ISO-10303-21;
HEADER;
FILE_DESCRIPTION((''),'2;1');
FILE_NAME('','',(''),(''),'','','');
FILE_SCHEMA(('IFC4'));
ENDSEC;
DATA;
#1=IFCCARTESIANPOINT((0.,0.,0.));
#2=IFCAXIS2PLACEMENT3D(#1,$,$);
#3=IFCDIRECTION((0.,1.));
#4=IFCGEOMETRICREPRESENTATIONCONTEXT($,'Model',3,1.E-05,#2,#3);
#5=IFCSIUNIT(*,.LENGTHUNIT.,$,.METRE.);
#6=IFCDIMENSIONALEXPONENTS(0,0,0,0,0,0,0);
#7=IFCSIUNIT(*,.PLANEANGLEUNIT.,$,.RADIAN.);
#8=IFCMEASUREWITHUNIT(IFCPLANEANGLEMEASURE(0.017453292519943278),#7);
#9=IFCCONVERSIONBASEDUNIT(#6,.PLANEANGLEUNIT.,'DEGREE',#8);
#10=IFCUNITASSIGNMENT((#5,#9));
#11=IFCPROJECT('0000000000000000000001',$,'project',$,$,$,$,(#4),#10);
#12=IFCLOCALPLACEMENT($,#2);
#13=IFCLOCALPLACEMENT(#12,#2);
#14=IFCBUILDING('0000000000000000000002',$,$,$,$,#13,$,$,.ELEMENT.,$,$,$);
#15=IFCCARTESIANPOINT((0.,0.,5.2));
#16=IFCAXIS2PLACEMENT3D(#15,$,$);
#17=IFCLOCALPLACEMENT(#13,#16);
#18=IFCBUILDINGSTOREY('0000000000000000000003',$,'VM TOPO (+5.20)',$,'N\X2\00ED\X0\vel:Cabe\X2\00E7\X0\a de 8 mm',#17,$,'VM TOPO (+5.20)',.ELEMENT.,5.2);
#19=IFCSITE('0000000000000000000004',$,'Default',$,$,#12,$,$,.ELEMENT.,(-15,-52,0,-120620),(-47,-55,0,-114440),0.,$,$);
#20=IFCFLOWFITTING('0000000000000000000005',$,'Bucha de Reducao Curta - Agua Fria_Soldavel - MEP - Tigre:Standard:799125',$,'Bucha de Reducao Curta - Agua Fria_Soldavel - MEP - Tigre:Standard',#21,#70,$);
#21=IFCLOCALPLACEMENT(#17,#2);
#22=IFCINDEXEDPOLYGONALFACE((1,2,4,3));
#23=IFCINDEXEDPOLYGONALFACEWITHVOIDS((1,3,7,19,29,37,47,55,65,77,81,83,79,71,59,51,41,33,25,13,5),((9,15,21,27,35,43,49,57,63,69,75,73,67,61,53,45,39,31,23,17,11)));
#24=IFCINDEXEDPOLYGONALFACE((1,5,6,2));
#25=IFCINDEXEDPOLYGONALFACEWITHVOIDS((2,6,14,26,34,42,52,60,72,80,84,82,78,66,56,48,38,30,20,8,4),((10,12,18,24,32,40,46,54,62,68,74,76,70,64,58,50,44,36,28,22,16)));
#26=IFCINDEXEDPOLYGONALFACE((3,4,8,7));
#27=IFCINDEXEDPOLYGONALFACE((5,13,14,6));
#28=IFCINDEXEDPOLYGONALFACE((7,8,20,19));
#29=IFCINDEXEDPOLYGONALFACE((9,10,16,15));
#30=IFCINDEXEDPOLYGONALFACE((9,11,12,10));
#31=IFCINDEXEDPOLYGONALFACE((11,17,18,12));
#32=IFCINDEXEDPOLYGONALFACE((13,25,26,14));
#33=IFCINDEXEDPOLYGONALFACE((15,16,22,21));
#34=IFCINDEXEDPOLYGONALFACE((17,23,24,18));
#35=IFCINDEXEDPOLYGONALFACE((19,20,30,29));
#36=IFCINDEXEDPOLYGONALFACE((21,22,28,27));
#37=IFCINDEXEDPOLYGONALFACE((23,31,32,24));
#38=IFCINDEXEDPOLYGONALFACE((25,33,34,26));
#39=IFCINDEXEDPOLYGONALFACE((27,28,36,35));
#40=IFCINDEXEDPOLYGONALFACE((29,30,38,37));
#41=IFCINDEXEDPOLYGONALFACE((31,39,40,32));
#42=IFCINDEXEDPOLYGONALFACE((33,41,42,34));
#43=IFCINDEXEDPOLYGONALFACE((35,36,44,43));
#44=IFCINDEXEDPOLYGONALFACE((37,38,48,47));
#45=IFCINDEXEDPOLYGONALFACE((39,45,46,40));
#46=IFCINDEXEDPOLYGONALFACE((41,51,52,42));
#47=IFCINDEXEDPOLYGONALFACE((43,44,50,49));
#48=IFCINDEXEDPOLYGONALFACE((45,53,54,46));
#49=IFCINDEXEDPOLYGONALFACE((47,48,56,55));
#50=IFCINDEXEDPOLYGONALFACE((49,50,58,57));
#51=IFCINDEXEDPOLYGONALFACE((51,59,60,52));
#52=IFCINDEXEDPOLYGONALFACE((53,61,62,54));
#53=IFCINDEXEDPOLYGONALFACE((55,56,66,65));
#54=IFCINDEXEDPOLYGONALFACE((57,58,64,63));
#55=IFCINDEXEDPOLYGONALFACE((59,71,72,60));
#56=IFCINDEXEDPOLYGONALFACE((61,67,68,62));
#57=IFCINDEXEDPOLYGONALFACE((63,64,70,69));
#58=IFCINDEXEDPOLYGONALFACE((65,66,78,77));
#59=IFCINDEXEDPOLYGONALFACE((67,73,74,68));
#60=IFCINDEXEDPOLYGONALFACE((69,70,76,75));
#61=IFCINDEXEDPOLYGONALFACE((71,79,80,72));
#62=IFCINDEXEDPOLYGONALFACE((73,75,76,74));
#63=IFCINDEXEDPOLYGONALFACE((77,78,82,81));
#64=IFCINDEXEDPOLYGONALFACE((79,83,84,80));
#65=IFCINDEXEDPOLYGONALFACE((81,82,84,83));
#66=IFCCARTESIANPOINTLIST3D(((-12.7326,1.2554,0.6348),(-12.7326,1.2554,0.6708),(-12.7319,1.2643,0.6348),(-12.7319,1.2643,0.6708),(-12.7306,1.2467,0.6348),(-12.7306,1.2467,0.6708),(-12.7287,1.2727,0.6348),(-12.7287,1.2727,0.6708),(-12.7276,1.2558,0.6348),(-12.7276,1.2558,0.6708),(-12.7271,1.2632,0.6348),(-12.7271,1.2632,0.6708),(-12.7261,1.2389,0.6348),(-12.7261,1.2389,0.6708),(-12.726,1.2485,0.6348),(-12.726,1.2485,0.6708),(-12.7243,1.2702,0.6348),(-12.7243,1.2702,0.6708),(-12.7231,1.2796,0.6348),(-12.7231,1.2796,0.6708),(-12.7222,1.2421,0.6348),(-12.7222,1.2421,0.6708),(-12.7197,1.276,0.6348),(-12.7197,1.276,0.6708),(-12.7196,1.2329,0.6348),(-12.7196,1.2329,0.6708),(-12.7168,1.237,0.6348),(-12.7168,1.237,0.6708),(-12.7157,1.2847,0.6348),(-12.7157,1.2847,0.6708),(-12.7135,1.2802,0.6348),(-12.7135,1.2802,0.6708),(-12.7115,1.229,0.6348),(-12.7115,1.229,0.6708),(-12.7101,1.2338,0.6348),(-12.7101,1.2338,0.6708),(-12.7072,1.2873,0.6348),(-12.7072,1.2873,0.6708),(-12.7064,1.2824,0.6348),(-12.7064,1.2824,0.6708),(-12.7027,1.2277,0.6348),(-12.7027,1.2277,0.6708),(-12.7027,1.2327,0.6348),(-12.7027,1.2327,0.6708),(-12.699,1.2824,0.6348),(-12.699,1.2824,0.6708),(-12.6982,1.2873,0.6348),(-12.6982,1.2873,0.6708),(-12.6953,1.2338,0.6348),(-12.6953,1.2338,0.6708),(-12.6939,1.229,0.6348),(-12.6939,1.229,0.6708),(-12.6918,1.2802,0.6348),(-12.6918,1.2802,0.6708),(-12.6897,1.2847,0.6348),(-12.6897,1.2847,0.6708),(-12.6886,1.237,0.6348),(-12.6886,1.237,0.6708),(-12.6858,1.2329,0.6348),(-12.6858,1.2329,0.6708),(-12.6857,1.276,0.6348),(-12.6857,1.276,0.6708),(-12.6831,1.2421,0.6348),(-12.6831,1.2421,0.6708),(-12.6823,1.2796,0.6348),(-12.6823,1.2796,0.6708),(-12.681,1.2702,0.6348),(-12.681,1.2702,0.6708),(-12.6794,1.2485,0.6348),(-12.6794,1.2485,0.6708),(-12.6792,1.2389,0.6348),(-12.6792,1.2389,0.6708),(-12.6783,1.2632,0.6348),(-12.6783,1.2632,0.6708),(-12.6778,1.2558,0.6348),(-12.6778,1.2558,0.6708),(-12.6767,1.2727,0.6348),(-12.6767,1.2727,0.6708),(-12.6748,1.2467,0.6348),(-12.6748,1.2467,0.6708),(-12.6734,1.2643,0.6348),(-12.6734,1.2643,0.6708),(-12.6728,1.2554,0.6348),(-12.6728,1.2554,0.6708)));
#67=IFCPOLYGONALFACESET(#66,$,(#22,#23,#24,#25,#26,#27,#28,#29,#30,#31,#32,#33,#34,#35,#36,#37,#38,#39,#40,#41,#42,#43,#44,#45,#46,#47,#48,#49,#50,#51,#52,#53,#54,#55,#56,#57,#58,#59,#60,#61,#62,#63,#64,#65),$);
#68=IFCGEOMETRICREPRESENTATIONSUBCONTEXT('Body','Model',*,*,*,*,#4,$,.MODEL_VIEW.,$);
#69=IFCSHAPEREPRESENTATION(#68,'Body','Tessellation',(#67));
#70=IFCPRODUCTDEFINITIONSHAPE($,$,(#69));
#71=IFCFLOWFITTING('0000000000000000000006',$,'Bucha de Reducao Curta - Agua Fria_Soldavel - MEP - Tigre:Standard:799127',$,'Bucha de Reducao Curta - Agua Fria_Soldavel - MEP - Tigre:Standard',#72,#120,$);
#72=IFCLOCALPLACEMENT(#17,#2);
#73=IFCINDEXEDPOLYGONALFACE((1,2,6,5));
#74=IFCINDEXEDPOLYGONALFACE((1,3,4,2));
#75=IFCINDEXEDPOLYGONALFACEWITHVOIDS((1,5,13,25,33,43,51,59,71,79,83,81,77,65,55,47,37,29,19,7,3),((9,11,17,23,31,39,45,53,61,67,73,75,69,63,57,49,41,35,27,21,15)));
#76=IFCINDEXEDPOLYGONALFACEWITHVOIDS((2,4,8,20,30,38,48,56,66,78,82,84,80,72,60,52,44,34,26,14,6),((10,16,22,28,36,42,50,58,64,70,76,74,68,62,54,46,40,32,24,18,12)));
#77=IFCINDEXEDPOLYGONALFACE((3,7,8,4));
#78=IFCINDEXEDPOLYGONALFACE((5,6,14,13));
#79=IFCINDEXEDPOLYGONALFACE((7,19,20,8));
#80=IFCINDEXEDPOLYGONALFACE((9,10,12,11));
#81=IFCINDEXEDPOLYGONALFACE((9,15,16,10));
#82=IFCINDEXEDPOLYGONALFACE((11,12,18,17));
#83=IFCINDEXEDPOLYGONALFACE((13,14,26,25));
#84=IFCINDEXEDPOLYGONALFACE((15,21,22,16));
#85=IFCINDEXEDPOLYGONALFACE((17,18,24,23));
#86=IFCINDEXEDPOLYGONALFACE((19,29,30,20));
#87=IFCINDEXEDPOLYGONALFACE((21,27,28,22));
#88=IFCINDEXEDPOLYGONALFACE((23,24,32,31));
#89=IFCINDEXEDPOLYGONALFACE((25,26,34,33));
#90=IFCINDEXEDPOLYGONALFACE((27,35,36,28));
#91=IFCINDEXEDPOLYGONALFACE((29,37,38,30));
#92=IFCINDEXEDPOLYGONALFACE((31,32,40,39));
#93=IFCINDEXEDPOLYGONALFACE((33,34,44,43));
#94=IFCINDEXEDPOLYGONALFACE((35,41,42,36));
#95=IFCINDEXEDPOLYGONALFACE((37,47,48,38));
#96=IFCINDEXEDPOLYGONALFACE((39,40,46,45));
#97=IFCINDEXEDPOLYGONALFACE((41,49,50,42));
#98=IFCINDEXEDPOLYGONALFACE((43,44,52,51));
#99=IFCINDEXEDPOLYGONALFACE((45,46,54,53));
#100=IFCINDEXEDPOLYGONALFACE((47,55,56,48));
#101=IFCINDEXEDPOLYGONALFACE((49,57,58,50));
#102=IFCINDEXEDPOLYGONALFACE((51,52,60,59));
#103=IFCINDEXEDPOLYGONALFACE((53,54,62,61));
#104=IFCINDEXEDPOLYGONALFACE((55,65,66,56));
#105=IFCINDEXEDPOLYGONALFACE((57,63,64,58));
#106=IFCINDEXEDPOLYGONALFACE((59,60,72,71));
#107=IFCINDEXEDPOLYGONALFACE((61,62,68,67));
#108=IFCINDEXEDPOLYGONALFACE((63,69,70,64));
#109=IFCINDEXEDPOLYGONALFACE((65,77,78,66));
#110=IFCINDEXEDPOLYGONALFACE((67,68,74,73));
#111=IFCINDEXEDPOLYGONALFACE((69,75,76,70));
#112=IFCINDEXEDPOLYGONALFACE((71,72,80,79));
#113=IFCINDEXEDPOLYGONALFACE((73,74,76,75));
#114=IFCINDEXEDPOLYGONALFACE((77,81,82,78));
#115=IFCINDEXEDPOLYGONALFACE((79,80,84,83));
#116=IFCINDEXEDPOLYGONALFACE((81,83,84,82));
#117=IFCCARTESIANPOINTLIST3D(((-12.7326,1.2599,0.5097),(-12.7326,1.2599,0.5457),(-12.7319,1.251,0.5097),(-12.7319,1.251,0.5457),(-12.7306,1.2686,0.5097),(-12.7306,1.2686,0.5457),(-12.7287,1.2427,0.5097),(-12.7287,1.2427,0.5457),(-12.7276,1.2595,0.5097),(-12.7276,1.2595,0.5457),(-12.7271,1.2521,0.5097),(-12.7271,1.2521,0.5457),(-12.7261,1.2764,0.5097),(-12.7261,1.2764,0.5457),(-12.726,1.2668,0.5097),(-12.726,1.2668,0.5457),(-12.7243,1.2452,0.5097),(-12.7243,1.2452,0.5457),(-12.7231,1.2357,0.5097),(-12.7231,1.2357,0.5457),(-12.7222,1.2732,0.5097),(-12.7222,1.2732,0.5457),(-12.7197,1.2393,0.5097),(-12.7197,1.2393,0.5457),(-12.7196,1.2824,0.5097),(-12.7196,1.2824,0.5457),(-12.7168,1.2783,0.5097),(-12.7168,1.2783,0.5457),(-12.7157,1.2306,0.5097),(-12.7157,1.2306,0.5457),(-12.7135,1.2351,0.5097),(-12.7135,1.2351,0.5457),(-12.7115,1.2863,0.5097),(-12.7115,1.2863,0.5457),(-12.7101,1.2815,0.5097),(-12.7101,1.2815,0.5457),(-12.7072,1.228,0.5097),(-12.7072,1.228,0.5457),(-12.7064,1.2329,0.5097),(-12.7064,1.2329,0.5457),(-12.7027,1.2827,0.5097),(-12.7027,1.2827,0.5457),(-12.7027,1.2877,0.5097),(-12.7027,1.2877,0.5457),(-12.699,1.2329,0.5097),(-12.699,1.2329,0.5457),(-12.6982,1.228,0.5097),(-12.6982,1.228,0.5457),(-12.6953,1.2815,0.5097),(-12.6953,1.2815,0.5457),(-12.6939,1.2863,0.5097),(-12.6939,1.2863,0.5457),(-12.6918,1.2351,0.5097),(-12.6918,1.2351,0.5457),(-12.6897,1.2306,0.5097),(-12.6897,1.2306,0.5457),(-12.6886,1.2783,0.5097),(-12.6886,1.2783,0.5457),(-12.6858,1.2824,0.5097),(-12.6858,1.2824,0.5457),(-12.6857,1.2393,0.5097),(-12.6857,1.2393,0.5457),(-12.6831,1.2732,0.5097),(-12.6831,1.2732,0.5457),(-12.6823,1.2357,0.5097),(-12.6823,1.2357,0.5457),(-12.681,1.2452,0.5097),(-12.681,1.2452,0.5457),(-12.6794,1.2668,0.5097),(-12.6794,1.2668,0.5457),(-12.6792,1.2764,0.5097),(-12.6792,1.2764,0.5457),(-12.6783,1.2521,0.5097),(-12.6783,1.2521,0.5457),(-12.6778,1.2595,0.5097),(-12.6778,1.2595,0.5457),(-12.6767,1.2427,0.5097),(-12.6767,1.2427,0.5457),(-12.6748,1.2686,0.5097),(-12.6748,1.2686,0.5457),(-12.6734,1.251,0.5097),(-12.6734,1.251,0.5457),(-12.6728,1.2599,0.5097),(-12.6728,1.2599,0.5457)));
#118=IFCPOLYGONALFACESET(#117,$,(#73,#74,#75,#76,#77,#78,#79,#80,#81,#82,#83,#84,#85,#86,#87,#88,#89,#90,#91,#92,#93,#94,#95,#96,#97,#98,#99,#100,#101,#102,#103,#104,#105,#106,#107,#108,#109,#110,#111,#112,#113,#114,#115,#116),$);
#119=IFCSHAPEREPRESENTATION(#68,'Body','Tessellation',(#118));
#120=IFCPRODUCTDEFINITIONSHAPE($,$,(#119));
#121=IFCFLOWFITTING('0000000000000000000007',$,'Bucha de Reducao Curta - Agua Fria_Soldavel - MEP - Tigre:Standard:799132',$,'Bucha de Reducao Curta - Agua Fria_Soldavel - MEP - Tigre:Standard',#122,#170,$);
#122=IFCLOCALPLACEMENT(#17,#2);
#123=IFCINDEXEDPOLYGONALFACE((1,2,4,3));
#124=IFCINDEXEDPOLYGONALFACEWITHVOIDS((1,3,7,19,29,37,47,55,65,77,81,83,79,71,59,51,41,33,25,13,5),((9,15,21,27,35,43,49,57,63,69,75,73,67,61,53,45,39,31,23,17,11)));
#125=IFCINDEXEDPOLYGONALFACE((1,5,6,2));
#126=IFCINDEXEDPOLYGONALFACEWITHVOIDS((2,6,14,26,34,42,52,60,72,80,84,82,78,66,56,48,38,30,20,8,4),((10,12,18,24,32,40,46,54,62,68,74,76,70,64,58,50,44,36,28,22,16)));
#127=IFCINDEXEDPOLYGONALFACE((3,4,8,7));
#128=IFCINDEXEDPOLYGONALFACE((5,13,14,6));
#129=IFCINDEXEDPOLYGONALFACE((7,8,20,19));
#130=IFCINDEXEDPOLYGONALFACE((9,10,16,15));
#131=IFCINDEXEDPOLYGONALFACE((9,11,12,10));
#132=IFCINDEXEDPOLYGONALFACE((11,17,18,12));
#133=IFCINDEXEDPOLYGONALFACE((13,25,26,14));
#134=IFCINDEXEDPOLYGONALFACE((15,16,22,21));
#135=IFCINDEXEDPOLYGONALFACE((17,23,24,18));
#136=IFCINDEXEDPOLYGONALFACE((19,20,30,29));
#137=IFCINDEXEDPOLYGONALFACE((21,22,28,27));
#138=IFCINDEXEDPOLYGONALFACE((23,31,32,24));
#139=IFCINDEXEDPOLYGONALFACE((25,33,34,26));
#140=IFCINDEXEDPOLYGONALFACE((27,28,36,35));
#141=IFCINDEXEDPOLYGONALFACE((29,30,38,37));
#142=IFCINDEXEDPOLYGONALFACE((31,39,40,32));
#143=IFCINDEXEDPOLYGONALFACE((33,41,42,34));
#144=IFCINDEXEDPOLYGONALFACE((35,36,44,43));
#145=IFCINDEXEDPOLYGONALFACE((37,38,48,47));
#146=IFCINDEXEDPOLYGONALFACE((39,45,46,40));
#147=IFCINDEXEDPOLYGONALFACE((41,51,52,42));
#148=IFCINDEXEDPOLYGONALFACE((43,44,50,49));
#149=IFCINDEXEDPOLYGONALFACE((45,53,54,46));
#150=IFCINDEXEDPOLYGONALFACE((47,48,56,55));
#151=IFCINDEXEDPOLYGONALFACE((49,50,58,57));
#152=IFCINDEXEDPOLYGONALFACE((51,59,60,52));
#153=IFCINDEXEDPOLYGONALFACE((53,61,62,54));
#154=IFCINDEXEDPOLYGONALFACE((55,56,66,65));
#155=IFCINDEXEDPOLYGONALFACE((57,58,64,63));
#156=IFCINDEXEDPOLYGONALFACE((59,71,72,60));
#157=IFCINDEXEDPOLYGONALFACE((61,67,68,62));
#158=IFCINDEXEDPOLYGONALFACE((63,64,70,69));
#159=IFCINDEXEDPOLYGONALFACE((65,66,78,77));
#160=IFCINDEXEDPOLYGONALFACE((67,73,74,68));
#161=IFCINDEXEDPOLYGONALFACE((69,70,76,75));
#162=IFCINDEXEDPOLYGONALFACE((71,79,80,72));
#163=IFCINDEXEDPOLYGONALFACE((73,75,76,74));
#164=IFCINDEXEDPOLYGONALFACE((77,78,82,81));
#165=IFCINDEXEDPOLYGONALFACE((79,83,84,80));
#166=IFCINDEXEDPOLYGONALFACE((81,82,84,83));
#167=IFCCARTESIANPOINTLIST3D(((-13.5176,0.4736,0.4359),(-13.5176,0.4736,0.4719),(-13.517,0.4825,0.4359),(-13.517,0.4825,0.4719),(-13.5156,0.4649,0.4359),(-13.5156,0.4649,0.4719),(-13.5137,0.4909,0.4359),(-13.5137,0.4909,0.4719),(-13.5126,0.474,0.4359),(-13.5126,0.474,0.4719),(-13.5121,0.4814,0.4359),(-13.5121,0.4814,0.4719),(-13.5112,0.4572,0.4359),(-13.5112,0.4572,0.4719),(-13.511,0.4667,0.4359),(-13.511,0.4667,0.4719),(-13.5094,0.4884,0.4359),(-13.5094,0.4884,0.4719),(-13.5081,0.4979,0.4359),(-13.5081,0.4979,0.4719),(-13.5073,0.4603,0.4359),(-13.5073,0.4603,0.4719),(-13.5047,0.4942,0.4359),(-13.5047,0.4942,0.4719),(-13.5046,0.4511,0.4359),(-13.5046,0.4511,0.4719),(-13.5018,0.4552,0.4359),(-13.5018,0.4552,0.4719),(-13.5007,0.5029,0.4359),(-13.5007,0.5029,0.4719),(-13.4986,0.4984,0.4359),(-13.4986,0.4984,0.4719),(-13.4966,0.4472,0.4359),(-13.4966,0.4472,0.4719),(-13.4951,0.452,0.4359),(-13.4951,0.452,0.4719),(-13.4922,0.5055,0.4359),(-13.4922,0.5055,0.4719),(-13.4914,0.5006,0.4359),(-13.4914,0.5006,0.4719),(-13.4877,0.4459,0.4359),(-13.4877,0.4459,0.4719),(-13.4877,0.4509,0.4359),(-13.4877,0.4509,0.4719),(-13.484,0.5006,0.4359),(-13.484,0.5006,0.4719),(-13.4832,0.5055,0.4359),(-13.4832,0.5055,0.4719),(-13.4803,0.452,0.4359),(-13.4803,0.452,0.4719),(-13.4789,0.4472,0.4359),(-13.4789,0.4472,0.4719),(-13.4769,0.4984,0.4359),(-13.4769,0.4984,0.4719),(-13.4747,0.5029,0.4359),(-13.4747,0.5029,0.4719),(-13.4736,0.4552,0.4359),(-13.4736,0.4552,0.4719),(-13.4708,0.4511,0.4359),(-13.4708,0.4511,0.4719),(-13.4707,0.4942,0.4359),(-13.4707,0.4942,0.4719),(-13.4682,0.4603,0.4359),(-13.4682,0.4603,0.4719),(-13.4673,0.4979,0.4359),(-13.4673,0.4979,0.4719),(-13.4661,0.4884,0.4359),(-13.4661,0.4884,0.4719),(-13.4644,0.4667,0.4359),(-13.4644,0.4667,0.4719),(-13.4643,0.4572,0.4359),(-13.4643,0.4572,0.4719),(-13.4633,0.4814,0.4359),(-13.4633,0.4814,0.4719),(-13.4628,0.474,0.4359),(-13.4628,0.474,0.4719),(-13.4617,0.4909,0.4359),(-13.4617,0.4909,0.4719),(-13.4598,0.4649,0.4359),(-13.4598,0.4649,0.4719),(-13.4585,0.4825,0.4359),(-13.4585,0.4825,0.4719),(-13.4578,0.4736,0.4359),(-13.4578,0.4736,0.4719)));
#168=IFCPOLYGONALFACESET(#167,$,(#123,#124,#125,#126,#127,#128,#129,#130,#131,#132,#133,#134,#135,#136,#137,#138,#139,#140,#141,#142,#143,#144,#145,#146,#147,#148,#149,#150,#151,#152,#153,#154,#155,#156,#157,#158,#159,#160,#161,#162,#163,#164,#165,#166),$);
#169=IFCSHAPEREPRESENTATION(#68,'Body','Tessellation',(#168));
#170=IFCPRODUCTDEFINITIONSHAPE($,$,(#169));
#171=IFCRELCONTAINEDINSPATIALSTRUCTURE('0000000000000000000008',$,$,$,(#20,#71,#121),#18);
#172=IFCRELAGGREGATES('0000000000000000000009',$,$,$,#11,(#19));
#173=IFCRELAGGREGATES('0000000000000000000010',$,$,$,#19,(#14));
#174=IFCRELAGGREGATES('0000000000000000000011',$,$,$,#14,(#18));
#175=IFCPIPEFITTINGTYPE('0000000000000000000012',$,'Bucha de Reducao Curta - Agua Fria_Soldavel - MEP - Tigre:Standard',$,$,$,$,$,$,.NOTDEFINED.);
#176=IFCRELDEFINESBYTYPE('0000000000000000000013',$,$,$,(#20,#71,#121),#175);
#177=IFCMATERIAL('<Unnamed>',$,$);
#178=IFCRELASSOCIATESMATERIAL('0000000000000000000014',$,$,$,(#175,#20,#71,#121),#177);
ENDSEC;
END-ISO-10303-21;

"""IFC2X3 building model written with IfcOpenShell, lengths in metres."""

from ifc_helpers import new_model, entity, si_unit, converted_unit, direction, frame, frame_2d, origin, place, context, subcontext, project, spatial, hollow_circle, extrude, source, transform, mapped, material, type_object, type_shapes, element, save


model = new_model("IFC2X3")

# Units and contexts
model_context = context("Model", 3, precision=1e-05, world=origin(), true_north=direction((0.0, 1.0)))
body_context = subcontext(model_context, "Body", "Model", "MODEL_VIEW")
ifc_project = project(units=[si_unit("LENGTHUNIT", "METRE"), converted_unit("PLANEANGLEUNIT", "DEGREE", entity("IfcPlaneAngleMeasure", 0.017453292519943278), si_unit("PLANEANGLEUNIT", "RADIAN"), dimensions=[0, 0, 0, 0, 0, 0, 0])], contexts=[model_context])

# Site, building, storey
site_placement = place(None, origin())
site = spatial("IfcSite", under=ifc_project, at=site_placement, Name="Default", CompositionType="ELEMENT", RefLatitude=(-15, -52, 0, -120620), RefLongitude=(-47, -55, 0, -114440), RefElevation=0.0)
building_placement = place(site_placement, origin())
building = spatial("IfcBuilding", under=site, at=building_placement, CompositionType="ELEMENT")
storey_placement = place(building_placement, frame((0.0, 0.0, 5.2)))
storey = spatial("IfcBuildingStorey", under=building, at=storey_placement, Name="VM TOPO (+5.20)", ObjectType="Nível:Cabeça de 8 mm", LongName="VM TOPO (+5.20)", CompositionType="ELEMENT", Elevation=5.2)

# Flow fittings
ifc_material_1 = material(Name="<Unnamed>")
pipe_fitting_type_1 = type_object("IfcPipeFittingType", Name="Bucha de Reducao Curta - Agua Fria_Soldavel - MEP - Tigre:Standard", PredefinedType="NOTDEFINED", material=ifc_material_1)
shared_shape_1 = source(origin(), body_context, "Body", "SweptSolid", [
    extrude(hollow_circle(Radius=0.03, WallThickness=0.005, at=frame_2d((0.0, 0.0), x_axis=(1.0, 0.0))), frame((0.0, 0.0, 0.0), z_axis=(1.0, 0.0, 0.0), x_axis=(0.0, 1.0, 0.0)), (0.0, 0.0, 1.0), 0.036),
])
type_shapes(pipe_fitting_type_1, [shared_shape_1])
for number, where, z_axis, x_axis, name in (
    (1, (-12.7027, 1.2577, 0.6708), (-1.0, 0.0, 0.0), (0.0, 0.0, -1.0), "Bucha de Reducao Curta - Agua Fria_Soldavel - MEP - Tigre:Standard:799125"),
    (2, (-12.7027, 1.2577, 0.5097), (-1.0, 0.0, 0.0), (0.0, 0.0, 1.0), "Bucha de Reducao Curta - Agua Fria_Soldavel - MEP - Tigre:Standard:799127"),
    (3, (-13.4877, 0.4759, 0.4359), (1.0, 0.0, 0.0), (0.0, 0.0, 1.0), "Bucha de Reducao Curta - Agua Fria_Soldavel - MEP - Tigre:Standard:799132"),
):
    element("IfcFlowFitting", number, at=place(storey_placement, frame(where, z_axis=z_axis, x_axis=x_axis)), inside=storey, type_object=pipe_fitting_type_1, material=ifc_material_1, Name=name, ObjectType="Bucha de Reducao Curta - Agua Fria_Soldavel - MEP - Tigre:Standard", context=body_context, shape_type="MappedRepresentation", body=[
        mapped(shared_shape_1, transform((0.0, 0.0, 0.0), scale=1.0)),
    ])

save(model, "model.ifc")
